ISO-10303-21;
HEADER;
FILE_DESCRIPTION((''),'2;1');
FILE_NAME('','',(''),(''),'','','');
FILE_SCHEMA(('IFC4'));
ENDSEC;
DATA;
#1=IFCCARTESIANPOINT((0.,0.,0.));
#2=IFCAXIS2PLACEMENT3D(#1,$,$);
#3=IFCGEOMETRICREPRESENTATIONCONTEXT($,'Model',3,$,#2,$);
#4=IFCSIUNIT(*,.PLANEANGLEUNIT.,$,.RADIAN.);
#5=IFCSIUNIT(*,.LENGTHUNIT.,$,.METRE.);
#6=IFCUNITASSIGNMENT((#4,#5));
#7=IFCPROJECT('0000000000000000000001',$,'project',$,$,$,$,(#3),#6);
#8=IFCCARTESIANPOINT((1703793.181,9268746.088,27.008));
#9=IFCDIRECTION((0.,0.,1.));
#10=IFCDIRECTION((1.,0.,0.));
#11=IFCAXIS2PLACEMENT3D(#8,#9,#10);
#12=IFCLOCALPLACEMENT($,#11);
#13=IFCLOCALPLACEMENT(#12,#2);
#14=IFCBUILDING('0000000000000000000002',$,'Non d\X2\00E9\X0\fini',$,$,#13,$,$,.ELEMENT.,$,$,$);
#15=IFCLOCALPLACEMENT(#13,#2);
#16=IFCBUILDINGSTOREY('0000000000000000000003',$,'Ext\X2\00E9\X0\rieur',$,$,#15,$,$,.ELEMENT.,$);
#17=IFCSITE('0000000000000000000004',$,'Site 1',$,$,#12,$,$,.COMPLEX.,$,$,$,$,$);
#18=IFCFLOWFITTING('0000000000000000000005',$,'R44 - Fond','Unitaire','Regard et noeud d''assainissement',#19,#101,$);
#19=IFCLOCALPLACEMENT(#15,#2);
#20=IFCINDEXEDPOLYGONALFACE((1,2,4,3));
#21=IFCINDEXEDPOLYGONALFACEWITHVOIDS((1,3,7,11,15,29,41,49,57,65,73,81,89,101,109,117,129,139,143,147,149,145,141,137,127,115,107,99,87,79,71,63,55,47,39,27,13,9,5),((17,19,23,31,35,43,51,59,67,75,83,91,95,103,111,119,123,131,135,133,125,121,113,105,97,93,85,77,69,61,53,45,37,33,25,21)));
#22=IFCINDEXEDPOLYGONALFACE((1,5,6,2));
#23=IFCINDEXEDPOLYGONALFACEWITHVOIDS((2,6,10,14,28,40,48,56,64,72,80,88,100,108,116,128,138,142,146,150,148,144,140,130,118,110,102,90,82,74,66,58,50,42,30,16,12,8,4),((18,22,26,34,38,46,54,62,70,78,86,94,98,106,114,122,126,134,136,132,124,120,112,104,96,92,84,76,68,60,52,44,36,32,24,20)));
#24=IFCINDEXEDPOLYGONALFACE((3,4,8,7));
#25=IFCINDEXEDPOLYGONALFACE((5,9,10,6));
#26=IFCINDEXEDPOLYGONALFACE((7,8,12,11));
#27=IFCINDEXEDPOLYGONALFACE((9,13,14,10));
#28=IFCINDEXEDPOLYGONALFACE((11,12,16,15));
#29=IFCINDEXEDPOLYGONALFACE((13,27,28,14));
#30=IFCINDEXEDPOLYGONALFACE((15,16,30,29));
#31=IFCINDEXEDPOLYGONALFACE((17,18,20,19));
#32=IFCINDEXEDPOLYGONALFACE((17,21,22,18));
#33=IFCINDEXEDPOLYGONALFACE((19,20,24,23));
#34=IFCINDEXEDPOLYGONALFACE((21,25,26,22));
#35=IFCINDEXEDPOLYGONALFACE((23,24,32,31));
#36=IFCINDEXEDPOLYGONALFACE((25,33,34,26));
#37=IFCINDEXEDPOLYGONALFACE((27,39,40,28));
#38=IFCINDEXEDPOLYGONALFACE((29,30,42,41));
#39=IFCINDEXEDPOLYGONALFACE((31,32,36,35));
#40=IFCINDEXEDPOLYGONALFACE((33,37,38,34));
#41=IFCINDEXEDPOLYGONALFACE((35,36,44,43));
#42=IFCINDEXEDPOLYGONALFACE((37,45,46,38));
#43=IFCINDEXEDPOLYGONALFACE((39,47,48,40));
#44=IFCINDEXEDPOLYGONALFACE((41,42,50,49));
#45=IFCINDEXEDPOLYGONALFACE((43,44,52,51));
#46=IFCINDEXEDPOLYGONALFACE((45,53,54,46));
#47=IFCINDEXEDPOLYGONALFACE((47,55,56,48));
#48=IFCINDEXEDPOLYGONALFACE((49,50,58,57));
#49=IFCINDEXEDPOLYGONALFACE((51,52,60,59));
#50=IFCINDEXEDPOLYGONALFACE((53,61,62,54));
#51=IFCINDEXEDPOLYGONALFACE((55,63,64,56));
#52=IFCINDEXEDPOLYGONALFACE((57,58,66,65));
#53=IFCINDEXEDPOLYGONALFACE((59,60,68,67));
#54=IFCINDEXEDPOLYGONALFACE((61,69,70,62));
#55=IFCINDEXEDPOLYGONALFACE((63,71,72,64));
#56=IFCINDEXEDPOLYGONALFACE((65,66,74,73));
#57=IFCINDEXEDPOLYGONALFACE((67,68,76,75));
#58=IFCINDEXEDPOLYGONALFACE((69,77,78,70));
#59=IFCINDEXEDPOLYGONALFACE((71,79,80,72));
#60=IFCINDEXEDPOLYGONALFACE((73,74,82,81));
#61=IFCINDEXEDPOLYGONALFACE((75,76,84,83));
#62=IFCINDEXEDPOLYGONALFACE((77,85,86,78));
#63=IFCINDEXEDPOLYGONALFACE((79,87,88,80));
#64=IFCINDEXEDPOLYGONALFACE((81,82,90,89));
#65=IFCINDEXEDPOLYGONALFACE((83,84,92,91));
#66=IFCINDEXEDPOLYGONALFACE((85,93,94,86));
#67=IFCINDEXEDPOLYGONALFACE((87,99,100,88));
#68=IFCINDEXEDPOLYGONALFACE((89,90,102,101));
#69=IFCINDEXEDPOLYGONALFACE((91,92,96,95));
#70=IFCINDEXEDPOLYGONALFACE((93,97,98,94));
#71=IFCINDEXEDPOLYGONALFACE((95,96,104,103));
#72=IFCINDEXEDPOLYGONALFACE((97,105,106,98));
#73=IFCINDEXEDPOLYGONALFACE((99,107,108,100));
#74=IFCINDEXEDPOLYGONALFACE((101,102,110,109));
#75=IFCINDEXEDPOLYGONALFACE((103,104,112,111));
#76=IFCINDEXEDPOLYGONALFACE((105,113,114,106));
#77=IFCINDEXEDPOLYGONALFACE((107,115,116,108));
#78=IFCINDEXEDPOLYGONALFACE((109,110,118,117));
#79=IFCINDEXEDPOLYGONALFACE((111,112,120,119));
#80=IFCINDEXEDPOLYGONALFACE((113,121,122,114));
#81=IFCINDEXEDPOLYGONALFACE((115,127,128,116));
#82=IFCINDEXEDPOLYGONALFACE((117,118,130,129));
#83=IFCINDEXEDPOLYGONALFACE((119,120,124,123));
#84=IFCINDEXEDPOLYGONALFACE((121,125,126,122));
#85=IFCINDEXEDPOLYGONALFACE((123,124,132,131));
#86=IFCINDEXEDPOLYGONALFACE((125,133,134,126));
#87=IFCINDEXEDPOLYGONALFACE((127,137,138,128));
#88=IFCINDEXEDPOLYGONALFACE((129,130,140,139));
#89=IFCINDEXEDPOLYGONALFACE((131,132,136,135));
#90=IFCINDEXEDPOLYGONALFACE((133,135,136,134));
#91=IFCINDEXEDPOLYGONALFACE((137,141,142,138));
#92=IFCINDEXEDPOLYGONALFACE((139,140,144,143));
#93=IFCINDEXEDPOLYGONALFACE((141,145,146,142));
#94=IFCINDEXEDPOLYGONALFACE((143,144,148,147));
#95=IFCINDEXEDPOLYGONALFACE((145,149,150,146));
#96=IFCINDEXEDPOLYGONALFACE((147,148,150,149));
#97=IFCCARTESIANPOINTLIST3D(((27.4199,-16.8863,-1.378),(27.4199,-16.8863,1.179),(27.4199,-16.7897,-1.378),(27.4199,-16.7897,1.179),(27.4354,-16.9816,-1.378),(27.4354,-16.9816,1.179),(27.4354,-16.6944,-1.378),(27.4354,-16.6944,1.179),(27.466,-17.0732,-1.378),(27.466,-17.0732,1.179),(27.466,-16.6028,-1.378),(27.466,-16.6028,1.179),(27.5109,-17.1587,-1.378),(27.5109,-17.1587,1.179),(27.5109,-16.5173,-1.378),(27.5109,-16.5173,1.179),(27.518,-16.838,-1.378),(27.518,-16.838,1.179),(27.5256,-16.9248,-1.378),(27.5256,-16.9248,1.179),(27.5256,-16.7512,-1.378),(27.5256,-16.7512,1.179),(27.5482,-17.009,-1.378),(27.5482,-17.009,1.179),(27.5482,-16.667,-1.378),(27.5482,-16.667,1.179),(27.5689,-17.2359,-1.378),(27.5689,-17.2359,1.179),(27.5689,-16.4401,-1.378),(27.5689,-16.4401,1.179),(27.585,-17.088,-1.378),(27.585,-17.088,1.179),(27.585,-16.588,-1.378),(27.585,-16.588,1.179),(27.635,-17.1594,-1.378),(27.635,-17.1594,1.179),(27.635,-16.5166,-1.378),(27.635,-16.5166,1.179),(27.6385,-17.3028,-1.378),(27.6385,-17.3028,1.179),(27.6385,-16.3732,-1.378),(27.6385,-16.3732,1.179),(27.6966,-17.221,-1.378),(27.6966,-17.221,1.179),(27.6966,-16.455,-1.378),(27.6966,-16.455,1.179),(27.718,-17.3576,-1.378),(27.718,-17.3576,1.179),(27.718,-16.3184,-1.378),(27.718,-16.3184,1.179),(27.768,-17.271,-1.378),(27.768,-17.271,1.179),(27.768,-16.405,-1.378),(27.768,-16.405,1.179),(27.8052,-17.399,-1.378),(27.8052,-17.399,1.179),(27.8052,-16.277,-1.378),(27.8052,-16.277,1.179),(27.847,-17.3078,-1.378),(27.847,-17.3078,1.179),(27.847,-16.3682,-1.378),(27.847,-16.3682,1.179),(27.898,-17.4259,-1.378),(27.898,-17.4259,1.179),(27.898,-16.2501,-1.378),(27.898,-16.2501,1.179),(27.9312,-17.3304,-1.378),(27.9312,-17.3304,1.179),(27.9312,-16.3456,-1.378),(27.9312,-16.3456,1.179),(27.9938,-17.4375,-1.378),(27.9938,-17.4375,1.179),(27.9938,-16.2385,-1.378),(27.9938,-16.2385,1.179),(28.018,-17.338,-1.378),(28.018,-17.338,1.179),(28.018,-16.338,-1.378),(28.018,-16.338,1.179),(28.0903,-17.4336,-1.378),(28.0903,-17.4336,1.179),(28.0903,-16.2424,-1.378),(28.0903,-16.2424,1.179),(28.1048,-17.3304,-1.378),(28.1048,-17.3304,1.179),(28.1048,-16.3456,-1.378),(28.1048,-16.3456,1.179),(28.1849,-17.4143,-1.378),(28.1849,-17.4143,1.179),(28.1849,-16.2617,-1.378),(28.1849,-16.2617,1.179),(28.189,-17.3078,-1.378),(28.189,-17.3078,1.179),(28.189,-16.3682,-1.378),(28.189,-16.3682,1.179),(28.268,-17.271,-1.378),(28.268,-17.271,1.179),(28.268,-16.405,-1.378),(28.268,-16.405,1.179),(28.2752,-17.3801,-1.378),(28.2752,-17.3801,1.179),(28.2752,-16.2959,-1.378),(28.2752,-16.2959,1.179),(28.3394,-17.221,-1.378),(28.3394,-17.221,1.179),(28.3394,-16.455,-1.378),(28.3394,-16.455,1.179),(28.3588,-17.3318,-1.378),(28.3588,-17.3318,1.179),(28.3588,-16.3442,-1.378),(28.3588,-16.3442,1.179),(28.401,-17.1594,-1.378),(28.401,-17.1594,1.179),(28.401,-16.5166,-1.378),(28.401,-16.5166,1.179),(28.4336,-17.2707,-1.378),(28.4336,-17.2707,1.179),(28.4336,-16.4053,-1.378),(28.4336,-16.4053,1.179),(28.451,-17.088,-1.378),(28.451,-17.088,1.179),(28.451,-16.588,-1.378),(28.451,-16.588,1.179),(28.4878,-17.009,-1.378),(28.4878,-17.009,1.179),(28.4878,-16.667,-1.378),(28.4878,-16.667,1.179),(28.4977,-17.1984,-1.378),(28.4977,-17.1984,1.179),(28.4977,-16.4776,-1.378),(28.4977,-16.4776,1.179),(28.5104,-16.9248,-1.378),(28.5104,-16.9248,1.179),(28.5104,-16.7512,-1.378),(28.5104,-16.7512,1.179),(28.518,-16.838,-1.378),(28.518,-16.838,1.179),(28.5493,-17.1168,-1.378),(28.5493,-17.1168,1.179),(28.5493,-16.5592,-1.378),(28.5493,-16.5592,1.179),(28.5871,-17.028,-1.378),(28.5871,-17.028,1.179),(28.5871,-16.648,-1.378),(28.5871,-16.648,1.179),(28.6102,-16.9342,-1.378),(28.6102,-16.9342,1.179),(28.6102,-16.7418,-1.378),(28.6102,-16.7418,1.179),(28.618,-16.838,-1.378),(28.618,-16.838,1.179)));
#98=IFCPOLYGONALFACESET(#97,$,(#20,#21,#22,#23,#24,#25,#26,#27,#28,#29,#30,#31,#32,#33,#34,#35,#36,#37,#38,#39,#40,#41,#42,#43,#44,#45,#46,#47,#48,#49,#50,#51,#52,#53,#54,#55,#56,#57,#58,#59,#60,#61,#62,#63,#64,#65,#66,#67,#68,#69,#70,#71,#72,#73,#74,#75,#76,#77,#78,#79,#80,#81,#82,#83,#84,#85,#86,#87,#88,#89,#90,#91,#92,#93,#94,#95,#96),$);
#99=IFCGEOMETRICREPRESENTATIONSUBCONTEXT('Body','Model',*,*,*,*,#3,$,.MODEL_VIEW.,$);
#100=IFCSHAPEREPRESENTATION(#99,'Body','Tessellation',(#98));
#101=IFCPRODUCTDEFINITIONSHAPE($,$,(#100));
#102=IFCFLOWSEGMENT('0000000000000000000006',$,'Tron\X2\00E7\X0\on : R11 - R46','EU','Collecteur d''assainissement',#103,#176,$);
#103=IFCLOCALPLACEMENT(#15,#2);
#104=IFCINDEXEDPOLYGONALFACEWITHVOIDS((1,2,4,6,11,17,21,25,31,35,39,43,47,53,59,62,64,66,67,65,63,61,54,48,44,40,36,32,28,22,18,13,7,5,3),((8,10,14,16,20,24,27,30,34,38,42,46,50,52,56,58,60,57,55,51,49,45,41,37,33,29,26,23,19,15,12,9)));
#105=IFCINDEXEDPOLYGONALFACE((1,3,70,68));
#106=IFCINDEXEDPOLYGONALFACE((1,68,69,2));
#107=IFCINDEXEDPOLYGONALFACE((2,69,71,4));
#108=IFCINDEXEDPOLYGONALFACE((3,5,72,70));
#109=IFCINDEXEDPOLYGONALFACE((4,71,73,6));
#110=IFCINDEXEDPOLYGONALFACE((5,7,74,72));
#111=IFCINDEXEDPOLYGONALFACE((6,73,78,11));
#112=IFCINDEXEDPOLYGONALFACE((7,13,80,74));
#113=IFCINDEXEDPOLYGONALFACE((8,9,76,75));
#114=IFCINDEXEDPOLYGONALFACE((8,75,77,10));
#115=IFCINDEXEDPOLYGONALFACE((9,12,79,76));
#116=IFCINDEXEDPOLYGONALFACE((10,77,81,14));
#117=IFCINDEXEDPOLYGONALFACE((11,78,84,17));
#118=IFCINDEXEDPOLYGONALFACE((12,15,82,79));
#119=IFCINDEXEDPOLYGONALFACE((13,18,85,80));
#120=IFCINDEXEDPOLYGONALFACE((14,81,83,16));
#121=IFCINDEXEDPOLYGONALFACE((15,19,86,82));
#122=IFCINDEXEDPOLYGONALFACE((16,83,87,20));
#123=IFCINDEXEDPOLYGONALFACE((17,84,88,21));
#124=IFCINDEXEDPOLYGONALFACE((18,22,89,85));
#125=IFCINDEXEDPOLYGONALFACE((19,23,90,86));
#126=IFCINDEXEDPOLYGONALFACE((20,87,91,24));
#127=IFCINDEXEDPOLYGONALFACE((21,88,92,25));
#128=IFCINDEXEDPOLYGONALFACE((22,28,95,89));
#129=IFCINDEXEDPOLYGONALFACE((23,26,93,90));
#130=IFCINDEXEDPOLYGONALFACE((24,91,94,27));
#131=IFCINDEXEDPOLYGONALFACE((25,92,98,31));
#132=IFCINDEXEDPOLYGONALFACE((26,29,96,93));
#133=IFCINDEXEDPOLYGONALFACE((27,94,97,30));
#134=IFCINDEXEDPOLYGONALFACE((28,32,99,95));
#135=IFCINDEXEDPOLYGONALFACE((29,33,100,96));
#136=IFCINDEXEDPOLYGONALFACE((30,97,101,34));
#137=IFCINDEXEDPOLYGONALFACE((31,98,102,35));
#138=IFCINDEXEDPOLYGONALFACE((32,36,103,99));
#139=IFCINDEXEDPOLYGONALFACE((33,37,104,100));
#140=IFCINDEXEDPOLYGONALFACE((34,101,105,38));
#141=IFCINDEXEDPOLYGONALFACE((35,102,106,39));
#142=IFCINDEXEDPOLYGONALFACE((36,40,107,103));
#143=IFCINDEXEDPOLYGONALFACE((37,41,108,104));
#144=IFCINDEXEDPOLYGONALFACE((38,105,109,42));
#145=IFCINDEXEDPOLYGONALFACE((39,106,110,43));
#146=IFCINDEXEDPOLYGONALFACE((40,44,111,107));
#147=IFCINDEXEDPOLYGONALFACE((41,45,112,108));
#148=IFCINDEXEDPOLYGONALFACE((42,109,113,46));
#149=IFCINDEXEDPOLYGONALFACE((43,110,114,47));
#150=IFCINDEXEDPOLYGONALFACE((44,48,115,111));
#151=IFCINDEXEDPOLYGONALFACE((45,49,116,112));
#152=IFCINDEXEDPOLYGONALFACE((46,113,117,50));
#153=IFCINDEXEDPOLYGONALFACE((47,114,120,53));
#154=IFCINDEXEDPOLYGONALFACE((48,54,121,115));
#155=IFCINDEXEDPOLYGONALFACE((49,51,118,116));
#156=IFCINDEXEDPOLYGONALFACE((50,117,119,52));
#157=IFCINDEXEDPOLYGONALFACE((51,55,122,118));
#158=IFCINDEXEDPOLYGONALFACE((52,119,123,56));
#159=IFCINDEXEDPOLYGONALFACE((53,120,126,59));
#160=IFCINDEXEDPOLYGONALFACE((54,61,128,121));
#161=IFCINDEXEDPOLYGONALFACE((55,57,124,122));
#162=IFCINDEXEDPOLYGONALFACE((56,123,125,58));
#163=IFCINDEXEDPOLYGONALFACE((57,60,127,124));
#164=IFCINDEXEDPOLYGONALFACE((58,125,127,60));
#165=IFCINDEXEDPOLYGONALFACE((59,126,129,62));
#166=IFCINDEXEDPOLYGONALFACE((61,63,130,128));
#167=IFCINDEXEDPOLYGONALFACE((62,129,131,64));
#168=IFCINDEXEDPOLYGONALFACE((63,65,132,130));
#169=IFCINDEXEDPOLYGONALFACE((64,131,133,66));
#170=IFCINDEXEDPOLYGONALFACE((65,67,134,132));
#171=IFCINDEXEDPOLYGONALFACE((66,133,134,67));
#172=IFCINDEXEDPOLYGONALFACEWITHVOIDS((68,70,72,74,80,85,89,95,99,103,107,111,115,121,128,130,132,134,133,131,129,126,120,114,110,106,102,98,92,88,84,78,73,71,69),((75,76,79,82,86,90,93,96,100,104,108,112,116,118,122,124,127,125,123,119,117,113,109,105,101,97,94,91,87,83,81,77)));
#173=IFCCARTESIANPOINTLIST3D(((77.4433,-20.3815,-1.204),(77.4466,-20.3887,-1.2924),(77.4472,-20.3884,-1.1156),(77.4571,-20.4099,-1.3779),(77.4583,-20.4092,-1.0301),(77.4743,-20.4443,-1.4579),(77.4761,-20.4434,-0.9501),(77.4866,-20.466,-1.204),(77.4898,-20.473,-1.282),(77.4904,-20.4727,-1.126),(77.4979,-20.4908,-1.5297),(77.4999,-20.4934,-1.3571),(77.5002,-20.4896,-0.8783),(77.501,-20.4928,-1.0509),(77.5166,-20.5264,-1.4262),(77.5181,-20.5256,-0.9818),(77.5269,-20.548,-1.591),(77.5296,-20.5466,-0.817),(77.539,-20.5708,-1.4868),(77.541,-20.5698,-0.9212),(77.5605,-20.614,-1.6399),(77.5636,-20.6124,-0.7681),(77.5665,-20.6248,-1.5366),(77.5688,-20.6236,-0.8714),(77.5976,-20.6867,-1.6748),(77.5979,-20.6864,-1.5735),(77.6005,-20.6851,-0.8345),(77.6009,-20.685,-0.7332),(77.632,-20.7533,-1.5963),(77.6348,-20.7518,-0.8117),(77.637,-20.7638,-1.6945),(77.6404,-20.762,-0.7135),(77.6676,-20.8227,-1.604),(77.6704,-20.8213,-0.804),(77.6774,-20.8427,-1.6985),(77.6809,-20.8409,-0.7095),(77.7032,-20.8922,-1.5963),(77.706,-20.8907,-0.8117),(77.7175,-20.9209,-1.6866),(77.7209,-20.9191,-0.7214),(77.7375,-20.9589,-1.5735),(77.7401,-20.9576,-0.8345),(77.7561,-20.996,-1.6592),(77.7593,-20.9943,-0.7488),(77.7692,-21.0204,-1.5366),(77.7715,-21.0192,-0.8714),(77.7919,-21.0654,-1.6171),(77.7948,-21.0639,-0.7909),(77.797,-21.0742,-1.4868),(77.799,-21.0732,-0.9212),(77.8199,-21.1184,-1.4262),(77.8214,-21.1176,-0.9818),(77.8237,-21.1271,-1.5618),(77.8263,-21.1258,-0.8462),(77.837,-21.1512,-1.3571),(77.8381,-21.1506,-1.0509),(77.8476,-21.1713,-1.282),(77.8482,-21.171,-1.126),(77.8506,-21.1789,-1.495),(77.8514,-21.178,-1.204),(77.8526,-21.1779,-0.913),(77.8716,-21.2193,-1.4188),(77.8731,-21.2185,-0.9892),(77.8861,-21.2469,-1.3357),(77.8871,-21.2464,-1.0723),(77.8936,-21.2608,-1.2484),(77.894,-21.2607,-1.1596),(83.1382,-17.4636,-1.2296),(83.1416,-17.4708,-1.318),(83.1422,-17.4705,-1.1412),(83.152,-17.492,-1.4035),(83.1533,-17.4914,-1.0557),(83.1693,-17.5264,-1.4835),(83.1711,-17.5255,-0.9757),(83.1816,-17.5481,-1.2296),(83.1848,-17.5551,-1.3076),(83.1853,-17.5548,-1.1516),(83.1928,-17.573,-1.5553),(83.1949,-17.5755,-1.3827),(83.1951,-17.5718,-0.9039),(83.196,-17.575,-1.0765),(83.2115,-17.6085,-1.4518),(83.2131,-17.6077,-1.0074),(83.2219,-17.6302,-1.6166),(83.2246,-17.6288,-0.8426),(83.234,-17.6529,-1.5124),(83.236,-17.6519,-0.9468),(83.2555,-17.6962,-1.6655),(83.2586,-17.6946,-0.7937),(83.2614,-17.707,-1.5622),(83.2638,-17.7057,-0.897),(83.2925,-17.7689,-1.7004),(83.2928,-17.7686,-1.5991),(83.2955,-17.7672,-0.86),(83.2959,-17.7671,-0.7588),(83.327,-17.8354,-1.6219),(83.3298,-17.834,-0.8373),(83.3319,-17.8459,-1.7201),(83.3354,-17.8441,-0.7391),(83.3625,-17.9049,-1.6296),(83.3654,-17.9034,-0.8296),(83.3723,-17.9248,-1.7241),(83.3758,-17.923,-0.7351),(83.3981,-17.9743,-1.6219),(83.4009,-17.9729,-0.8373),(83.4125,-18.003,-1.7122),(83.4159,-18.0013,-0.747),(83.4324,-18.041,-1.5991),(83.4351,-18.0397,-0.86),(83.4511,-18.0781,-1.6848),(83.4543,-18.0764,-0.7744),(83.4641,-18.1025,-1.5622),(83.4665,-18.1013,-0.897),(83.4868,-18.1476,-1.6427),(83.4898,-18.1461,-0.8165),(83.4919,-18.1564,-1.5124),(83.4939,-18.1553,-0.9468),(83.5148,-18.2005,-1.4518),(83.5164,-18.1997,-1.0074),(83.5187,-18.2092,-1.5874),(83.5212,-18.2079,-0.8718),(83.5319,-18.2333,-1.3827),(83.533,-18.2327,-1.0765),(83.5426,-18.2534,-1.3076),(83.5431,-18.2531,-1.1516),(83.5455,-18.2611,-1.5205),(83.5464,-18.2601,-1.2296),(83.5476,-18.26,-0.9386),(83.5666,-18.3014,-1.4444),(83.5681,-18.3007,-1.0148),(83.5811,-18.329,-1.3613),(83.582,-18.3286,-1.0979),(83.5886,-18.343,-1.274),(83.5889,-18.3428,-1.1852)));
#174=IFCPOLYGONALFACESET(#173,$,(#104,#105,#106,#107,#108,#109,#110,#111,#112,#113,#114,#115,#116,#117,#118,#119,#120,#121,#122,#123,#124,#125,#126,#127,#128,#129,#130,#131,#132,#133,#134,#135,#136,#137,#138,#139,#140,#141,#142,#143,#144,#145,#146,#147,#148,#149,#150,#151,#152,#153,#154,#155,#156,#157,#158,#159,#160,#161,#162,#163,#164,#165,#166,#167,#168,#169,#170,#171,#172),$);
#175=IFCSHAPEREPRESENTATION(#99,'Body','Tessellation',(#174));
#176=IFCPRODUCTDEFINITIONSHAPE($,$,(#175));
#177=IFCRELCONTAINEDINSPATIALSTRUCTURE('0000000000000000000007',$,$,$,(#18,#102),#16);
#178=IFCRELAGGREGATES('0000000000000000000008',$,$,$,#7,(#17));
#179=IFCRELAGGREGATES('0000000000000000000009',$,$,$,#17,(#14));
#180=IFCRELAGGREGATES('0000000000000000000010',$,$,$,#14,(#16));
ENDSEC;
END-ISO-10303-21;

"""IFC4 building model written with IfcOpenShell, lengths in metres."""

from ifc_helpers import new_model, si_unit, frame, origin, origin_2d, place, context, subcontext, project, spatial, hollow_circle, extrude, element, save


model = new_model("IFC4")

# Units and contexts
model_context = context("Model", 3, world=origin())
body_context = subcontext(model_context, "Body", "Model", "MODEL_VIEW")
ifc_project = project(units=[si_unit("PLANEANGLEUNIT", "RADIAN"), si_unit("LENGTHUNIT", "METRE")], contexts=[model_context])

# Site, building, storey
site_placement = place(None, frame((1703793.181, 9268746.088, 27.008), z_axis=(0.0, 0.0, 1.0), x_axis=(1.0, 0.0, 0.0)))
site = spatial("IfcSite", under=ifc_project, at=site_placement, Name="Site 1", CompositionType="COMPLEX")
building_placement = place(site_placement, origin())
building = spatial("IfcBuilding", under=site, at=building_placement, Name="Non défini", CompositionType="ELEMENT")
storey_placement = place(building_placement, origin())
storey = spatial("IfcBuildingStorey", under=building, at=storey_placement, Name="Extérieur", CompositionType="ELEMENT")

# Flow fitting
flow_fitting_1_placement = place(storey_placement, origin())
element("IfcFlowFitting", 1, at=flow_fitting_1_placement, inside=storey, Name="R44 - Fond", Description="Unitaire", ObjectType="Regard et noeud d'assainissement", context=body_context, shape_type="SweptSolid", body=[
    extrude(hollow_circle(Radius=0.6, WallThickness=0.1, at=origin_2d()), frame((28.018, -16.838, -1.378), z_axis=(0.0, 0.0, 1.0), x_axis=(1.0, 0.0, 0.0)), (0.0, 0.0, 1.0), 2.557),
])

# Flow segment
flow_segment_1_placement = place(storey_placement, origin())
element("IfcFlowSegment", 2, at=flow_segment_1_placement, inside=storey, Name="Tronçon : R11 - R46", Description="EU", ObjectType="Collecteur d'assainissement", context=body_context, shape_type="SweptSolid", body=[
    extrude(hollow_circle(Radius=0.495, WallThickness=0.095, at=origin_2d()), frame((77.669, -20.822, -1.204), z_axis=(0.89, 0.456, -0.004), x_axis=(-0.456, 0.89, 0.0)), (0.0, 0.0, 1.0), 6.399),
])

save(model, "model.ifc")
